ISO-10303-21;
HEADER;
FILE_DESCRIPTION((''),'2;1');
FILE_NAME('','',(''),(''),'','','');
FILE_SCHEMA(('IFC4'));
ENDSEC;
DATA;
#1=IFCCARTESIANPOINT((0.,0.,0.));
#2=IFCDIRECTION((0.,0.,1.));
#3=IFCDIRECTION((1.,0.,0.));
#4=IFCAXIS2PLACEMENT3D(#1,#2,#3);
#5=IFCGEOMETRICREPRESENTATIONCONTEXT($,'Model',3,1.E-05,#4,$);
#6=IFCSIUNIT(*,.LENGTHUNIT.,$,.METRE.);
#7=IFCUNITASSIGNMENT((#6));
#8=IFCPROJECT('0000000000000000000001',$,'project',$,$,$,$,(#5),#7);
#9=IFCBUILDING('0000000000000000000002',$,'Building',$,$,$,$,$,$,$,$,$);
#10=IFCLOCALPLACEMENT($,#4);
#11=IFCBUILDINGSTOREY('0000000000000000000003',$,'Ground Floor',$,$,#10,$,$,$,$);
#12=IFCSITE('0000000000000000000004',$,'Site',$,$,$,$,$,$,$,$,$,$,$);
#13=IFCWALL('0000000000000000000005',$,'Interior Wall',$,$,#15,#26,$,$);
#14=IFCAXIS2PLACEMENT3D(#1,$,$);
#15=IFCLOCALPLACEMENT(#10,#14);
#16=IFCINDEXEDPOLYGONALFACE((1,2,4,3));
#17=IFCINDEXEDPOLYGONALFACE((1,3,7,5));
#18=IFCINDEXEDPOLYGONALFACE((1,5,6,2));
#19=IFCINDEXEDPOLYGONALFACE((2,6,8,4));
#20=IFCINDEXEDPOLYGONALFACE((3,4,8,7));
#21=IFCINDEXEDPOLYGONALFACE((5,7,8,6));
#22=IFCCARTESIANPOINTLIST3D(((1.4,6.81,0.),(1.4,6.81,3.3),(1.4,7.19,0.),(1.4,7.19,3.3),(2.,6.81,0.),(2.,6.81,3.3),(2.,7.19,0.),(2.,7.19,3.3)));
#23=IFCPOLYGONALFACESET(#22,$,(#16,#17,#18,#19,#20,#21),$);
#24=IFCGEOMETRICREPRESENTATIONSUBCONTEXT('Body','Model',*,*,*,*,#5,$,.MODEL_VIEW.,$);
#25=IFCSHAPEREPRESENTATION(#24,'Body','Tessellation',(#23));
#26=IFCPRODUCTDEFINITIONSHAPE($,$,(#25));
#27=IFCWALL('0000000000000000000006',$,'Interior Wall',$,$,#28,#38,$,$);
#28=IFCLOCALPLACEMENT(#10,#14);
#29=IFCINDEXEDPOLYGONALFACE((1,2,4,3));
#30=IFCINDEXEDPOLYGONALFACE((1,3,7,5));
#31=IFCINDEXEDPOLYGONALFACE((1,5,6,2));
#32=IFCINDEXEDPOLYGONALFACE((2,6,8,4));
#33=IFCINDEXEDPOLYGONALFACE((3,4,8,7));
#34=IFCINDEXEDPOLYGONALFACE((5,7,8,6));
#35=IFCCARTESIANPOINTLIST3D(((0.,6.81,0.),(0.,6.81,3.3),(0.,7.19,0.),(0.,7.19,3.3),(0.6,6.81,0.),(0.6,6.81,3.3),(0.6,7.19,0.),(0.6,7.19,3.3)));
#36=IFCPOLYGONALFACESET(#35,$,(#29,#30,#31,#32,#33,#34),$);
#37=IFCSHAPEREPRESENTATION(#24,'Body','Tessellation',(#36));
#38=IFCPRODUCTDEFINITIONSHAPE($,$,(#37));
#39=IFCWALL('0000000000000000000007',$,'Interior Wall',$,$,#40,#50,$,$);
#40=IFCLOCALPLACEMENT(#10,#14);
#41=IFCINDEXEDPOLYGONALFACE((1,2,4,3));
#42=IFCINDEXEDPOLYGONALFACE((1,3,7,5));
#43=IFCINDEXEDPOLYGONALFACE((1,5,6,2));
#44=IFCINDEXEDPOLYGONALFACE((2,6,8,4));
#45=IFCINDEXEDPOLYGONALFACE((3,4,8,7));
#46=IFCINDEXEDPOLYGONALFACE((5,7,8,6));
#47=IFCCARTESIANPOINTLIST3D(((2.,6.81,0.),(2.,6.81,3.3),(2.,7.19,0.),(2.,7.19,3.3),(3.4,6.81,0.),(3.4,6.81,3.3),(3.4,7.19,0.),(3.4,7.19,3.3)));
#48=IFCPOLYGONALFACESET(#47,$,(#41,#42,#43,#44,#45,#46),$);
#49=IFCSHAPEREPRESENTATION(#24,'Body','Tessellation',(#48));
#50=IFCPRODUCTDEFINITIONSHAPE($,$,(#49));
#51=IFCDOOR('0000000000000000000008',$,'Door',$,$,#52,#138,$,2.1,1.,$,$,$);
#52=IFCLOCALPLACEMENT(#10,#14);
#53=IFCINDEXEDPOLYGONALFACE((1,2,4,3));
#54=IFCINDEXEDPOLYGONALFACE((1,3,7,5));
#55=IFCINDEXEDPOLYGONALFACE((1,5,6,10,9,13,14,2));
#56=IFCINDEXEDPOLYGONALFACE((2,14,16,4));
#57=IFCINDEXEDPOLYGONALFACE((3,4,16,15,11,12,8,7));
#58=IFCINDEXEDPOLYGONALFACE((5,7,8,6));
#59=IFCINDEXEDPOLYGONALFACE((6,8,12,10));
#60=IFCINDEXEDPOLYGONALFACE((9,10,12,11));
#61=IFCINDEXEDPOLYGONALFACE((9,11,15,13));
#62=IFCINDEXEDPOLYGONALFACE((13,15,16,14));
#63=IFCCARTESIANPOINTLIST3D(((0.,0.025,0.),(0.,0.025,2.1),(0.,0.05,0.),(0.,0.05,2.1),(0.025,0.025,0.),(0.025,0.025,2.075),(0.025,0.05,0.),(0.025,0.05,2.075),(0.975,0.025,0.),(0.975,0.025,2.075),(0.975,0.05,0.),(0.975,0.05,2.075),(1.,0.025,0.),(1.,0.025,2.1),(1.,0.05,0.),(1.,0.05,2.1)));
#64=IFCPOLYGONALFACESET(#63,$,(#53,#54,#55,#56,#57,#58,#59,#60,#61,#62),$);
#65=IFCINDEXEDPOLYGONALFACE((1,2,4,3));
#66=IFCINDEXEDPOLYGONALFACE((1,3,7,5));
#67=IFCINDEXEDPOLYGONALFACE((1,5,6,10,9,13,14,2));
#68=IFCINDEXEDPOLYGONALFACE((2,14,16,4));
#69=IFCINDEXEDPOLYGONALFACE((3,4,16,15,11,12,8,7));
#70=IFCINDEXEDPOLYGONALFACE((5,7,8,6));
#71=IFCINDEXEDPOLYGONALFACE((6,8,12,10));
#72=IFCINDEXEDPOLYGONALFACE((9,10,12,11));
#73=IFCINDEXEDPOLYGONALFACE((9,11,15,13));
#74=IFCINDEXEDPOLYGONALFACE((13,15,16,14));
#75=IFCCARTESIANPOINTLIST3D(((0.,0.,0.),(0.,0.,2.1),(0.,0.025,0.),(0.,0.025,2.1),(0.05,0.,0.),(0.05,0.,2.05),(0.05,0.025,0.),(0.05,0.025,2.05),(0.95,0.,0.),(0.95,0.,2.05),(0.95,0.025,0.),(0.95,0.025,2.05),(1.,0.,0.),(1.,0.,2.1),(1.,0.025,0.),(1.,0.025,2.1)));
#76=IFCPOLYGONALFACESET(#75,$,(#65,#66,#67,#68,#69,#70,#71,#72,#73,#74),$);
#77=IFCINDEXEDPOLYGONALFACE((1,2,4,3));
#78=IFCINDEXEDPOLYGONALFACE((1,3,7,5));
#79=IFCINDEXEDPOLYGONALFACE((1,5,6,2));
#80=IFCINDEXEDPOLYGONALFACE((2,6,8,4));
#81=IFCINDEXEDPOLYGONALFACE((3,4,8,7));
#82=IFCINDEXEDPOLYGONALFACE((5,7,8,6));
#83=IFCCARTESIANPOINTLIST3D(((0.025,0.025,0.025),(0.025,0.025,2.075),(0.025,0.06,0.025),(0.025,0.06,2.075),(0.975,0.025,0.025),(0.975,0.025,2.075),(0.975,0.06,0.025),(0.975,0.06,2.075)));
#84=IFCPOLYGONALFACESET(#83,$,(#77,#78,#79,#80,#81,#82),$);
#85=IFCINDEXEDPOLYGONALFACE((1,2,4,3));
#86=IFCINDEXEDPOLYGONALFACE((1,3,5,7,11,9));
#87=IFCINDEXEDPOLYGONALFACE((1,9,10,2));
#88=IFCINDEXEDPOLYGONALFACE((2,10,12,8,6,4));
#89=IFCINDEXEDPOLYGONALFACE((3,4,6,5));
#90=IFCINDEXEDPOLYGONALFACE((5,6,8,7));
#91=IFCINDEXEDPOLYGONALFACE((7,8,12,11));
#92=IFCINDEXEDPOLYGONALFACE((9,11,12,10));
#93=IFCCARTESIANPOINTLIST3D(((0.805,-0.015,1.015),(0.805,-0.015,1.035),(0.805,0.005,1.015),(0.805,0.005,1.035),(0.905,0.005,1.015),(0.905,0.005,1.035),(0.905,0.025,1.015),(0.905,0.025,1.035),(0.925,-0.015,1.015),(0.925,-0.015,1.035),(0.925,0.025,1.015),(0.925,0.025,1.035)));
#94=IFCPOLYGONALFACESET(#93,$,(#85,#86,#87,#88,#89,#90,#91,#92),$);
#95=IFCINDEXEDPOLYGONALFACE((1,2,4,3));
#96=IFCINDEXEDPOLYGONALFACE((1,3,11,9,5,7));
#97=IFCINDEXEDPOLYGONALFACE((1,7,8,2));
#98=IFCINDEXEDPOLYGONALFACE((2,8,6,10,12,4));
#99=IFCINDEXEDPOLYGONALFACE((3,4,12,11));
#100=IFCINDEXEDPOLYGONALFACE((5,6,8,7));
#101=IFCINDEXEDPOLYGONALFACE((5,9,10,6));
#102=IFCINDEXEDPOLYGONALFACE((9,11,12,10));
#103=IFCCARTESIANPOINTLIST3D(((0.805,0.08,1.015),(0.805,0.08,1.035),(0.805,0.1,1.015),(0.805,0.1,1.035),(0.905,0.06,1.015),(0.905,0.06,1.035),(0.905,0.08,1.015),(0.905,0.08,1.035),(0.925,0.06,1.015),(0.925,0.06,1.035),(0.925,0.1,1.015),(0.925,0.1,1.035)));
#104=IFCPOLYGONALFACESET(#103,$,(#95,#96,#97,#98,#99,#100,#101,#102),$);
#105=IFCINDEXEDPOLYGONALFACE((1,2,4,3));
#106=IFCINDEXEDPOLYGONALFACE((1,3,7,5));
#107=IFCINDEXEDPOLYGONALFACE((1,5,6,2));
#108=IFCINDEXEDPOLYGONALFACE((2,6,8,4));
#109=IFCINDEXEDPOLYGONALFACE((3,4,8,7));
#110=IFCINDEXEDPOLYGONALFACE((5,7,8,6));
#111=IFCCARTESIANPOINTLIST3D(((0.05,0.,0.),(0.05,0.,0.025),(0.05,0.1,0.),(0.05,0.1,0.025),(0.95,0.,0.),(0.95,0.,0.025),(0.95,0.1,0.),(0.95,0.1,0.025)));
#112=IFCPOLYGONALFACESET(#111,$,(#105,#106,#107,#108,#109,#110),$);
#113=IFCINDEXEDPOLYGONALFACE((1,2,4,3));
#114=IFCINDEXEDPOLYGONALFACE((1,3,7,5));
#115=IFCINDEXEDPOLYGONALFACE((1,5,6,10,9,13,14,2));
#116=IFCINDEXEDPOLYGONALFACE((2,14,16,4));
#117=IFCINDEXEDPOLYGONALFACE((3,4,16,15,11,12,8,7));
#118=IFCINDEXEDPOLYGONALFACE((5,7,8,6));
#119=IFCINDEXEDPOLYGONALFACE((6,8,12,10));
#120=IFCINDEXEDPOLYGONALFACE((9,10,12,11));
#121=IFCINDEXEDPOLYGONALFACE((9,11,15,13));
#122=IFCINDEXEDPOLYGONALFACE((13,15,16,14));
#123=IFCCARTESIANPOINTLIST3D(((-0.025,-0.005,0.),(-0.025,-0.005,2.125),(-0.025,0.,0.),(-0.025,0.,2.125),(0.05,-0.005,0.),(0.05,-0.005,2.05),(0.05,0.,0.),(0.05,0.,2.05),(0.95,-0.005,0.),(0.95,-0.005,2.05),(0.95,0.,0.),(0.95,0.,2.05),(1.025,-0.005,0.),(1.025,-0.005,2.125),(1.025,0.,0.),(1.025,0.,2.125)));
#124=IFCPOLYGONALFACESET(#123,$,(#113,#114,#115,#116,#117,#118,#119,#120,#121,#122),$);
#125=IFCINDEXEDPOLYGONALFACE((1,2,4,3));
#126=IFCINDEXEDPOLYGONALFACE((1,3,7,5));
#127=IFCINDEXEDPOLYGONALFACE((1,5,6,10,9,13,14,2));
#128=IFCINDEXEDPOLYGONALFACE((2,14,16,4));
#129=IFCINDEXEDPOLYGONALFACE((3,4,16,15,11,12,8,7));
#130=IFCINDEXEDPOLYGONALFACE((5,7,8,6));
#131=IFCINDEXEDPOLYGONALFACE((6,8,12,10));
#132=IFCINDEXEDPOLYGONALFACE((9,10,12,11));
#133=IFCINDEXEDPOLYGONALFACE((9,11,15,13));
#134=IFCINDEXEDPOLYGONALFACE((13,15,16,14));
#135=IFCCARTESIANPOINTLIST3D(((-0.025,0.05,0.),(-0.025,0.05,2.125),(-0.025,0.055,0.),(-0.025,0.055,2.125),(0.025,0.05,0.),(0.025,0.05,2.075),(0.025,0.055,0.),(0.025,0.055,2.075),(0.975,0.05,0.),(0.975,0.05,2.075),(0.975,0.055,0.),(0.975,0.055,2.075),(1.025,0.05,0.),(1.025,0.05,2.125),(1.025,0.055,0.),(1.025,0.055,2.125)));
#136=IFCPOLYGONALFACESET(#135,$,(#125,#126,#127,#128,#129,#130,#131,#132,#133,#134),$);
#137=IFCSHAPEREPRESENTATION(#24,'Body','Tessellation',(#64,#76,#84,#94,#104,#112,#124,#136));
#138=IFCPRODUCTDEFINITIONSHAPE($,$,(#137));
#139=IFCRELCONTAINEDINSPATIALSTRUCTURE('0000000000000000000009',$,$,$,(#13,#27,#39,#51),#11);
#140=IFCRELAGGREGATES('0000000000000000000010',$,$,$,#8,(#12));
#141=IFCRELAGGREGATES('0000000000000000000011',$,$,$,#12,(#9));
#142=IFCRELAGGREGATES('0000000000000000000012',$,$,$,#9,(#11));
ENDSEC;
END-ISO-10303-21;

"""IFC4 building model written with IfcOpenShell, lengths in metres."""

from ifc_helpers import new_model, si_unit, frame, origin_with_axes, place, context, subcontext, project, spatial, line, indexed_curve, outline, extrude, element, save


model = new_model("IFC4")

# Units and contexts
model_context = context("Model", 3, precision=1e-05, world=origin_with_axes())
body_context = subcontext(model_context, "Body", "Model", "MODEL_VIEW")
ifc_project = project(units=[si_unit("LENGTHUNIT", "METRE")], contexts=[model_context])

# Site, building, storey
site = spatial("IfcSite", under=ifc_project, Name="Site")
building = spatial("IfcBuilding", under=site, Name="Building")
storey_placement = place(None, origin_with_axes())
storey = spatial("IfcBuildingStorey", under=building, at=storey_placement, Name="Ground Floor")

# Walls
for number, where, z_axis, x_axis, name in (
    (1, (2.0, 7.0, 0.0), (0.0, 0.0, 1.0), (-1.0, 0.0, 0.0), "Interior Wall"),
    (2, (0.6, 7.0, 0.0), (0.0, 0.0, 1.0), (-1.0, 0.0, 0.0), "Interior Wall"),
):
    element("IfcWall", number, at=place(storey_placement, frame(where, z_axis=z_axis, x_axis=x_axis)), inside=storey, Name=name, context=body_context, shape_type="SweptSolid", body=[
        extrude(outline(indexed_curve([(0.0, 0.0), (0.0, 0.38), (0.6, 0.38), (0.6, 0.0), (0.0, 0.0)], self_intersect=False)), frame((0.0, -0.19, 0.0), z_axis=(0.0, 0.0, 1.0), x_axis=(1.0, 0.0, 0.0)), (0.0, 0.0, 1.0), 3.3),
    ])
wall_1_placement = place(storey_placement, frame((3.4, 7.0, 0.0), z_axis=(0.0, 0.0, 1.0), x_axis=(-1.0, 0.0, 0.0)))
element("IfcWall", 3, at=wall_1_placement, inside=storey, Name="Interior Wall", context=body_context, shape_type="SweptSolid", body=[
    extrude(outline(indexed_curve([(0.0, 0.0), (0.0, 0.38), (1.4, 0.38), (1.4, 0.0), (0.0, 0.0)], self_intersect=False)), frame((0.0, -0.19, 0.0), z_axis=(0.0, 0.0, 1.0), x_axis=(1.0, 0.0, 0.0)), (0.0, 0.0, 1.0), 3.3),
])

# Door
door_1_placement = place(storey_placement, origin_with_axes())
element("IfcDoor", 4, at=door_1_placement, inside=storey, Name="Door", OverallHeight=2.1, OverallWidth=1.0, context=body_context, shape_type="SweptSolid", body=[
    extrude(outline(indexed_curve([(0.0, 0.0), (0.0, 2.1), (1.0, 2.1), (1.0, 0.0), (0.975, 0.0), (0.975, 2.075), (0.025, 2.075), (0.025, 0.0)], segments=[line(1, 2, 3, 4, 5, 6, 7, 8, 1)])), frame((0.0, 0.025, 0.0), z_axis=(0.0, -1.0, 0.0), x_axis=(1.0, 0.0, 0.0)), (0.0, 0.0, -1.0), 0.025),
    extrude(outline(indexed_curve([(0.0, 0.0), (0.0, 2.1), (1.0, 2.1), (1.0, 0.0), (0.95, 0.0), (0.95, 2.05), (0.05, 2.05), (0.05, 0.0)], segments=[line(1, 2, 3, 4, 5, 6, 7, 8, 1)])), frame((0.0, 0.0, 0.0), z_axis=(0.0, -1.0, 0.0), x_axis=(1.0, 0.0, 0.0)), (0.0, 0.0, -1.0), 0.025),
    extrude(outline(indexed_curve([(0.0, 0.0), (0.95, 0.0), (0.95, 0.035), (0.0, 0.035)], segments=[line(1, 2, 3, 4, 1)])), frame((0.025, 0.025, 0.025), z_axis=(0.0, 0.0, 1.0), x_axis=(1.0, 0.0, 0.0)), (0.0, 0.0, 1.0), 2.05),
    extrude(outline(indexed_curve([(0.0, 0.0), (0.0, -0.04), (-0.12, -0.04), (-0.12, -0.02), (-0.02, -0.02), (-0.02, 0.0)], segments=[line(1, 2, 3, 4, 5, 6, 1)])), frame((0.925, 0.025, 1.015), z_axis=(0.0, 0.0, 1.0), x_axis=(1.0, 0.0, 0.0)), (0.0, 0.0, 1.0), 0.02),
    extrude(outline(indexed_curve([(0.0, 0.0), (0.0, 0.04), (-0.12, 0.04), (-0.12, 0.02), (-0.02, 0.02), (-0.02, 0.0)], segments=[line(1, 2, 3, 4, 5, 6, 1)])), frame((0.925, 0.06, 1.015), z_axis=(0.0, 0.0, 1.0), x_axis=(1.0, 0.0, 0.0)), (0.0, 0.0, 1.0), 0.02),
    extrude(outline(indexed_curve([(0.0, 0.0), (0.9, 0.0), (0.9, 0.1), (0.0, 0.1)], segments=[line(1, 2, 3, 4, 1)])), frame((0.05, 0.0, 0.0), z_axis=(0.0, 0.0, 1.0), x_axis=(1.0, 0.0, 0.0)), (0.0, 0.0, 1.0), 0.025),
    extrude(outline(indexed_curve([(0.0, 0.0), (0.0, 2.125), (1.05, 2.125), (1.05, 0.0), (0.975, 0.0), (0.975, 2.05), (0.075, 2.05), (0.075, 0.0)], segments=[line(1, 2, 3, 4, 5, 6, 7, 8, 1)])), frame((-0.025, -0.005, 0.0), z_axis=(0.0, -1.0, 0.0), x_axis=(1.0, 0.0, 0.0)), (0.0, 0.0, -1.0), 0.005),
    extrude(outline(indexed_curve([(0.0, 0.0), (0.0, 2.125), (1.05, 2.125), (1.05, 0.0), (1.0, 0.0), (1.0, 2.075), (0.05, 2.075), (0.05, 0.0)], segments=[line(1, 2, 3, 4, 5, 6, 7, 8, 1)])), frame((-0.025, 0.05, 0.0), z_axis=(0.0, -1.0, 0.0), x_axis=(1.0, 0.0, 0.0)), (0.0, 0.0, -1.0), 0.005),
])

save(model, "model.ifc")
